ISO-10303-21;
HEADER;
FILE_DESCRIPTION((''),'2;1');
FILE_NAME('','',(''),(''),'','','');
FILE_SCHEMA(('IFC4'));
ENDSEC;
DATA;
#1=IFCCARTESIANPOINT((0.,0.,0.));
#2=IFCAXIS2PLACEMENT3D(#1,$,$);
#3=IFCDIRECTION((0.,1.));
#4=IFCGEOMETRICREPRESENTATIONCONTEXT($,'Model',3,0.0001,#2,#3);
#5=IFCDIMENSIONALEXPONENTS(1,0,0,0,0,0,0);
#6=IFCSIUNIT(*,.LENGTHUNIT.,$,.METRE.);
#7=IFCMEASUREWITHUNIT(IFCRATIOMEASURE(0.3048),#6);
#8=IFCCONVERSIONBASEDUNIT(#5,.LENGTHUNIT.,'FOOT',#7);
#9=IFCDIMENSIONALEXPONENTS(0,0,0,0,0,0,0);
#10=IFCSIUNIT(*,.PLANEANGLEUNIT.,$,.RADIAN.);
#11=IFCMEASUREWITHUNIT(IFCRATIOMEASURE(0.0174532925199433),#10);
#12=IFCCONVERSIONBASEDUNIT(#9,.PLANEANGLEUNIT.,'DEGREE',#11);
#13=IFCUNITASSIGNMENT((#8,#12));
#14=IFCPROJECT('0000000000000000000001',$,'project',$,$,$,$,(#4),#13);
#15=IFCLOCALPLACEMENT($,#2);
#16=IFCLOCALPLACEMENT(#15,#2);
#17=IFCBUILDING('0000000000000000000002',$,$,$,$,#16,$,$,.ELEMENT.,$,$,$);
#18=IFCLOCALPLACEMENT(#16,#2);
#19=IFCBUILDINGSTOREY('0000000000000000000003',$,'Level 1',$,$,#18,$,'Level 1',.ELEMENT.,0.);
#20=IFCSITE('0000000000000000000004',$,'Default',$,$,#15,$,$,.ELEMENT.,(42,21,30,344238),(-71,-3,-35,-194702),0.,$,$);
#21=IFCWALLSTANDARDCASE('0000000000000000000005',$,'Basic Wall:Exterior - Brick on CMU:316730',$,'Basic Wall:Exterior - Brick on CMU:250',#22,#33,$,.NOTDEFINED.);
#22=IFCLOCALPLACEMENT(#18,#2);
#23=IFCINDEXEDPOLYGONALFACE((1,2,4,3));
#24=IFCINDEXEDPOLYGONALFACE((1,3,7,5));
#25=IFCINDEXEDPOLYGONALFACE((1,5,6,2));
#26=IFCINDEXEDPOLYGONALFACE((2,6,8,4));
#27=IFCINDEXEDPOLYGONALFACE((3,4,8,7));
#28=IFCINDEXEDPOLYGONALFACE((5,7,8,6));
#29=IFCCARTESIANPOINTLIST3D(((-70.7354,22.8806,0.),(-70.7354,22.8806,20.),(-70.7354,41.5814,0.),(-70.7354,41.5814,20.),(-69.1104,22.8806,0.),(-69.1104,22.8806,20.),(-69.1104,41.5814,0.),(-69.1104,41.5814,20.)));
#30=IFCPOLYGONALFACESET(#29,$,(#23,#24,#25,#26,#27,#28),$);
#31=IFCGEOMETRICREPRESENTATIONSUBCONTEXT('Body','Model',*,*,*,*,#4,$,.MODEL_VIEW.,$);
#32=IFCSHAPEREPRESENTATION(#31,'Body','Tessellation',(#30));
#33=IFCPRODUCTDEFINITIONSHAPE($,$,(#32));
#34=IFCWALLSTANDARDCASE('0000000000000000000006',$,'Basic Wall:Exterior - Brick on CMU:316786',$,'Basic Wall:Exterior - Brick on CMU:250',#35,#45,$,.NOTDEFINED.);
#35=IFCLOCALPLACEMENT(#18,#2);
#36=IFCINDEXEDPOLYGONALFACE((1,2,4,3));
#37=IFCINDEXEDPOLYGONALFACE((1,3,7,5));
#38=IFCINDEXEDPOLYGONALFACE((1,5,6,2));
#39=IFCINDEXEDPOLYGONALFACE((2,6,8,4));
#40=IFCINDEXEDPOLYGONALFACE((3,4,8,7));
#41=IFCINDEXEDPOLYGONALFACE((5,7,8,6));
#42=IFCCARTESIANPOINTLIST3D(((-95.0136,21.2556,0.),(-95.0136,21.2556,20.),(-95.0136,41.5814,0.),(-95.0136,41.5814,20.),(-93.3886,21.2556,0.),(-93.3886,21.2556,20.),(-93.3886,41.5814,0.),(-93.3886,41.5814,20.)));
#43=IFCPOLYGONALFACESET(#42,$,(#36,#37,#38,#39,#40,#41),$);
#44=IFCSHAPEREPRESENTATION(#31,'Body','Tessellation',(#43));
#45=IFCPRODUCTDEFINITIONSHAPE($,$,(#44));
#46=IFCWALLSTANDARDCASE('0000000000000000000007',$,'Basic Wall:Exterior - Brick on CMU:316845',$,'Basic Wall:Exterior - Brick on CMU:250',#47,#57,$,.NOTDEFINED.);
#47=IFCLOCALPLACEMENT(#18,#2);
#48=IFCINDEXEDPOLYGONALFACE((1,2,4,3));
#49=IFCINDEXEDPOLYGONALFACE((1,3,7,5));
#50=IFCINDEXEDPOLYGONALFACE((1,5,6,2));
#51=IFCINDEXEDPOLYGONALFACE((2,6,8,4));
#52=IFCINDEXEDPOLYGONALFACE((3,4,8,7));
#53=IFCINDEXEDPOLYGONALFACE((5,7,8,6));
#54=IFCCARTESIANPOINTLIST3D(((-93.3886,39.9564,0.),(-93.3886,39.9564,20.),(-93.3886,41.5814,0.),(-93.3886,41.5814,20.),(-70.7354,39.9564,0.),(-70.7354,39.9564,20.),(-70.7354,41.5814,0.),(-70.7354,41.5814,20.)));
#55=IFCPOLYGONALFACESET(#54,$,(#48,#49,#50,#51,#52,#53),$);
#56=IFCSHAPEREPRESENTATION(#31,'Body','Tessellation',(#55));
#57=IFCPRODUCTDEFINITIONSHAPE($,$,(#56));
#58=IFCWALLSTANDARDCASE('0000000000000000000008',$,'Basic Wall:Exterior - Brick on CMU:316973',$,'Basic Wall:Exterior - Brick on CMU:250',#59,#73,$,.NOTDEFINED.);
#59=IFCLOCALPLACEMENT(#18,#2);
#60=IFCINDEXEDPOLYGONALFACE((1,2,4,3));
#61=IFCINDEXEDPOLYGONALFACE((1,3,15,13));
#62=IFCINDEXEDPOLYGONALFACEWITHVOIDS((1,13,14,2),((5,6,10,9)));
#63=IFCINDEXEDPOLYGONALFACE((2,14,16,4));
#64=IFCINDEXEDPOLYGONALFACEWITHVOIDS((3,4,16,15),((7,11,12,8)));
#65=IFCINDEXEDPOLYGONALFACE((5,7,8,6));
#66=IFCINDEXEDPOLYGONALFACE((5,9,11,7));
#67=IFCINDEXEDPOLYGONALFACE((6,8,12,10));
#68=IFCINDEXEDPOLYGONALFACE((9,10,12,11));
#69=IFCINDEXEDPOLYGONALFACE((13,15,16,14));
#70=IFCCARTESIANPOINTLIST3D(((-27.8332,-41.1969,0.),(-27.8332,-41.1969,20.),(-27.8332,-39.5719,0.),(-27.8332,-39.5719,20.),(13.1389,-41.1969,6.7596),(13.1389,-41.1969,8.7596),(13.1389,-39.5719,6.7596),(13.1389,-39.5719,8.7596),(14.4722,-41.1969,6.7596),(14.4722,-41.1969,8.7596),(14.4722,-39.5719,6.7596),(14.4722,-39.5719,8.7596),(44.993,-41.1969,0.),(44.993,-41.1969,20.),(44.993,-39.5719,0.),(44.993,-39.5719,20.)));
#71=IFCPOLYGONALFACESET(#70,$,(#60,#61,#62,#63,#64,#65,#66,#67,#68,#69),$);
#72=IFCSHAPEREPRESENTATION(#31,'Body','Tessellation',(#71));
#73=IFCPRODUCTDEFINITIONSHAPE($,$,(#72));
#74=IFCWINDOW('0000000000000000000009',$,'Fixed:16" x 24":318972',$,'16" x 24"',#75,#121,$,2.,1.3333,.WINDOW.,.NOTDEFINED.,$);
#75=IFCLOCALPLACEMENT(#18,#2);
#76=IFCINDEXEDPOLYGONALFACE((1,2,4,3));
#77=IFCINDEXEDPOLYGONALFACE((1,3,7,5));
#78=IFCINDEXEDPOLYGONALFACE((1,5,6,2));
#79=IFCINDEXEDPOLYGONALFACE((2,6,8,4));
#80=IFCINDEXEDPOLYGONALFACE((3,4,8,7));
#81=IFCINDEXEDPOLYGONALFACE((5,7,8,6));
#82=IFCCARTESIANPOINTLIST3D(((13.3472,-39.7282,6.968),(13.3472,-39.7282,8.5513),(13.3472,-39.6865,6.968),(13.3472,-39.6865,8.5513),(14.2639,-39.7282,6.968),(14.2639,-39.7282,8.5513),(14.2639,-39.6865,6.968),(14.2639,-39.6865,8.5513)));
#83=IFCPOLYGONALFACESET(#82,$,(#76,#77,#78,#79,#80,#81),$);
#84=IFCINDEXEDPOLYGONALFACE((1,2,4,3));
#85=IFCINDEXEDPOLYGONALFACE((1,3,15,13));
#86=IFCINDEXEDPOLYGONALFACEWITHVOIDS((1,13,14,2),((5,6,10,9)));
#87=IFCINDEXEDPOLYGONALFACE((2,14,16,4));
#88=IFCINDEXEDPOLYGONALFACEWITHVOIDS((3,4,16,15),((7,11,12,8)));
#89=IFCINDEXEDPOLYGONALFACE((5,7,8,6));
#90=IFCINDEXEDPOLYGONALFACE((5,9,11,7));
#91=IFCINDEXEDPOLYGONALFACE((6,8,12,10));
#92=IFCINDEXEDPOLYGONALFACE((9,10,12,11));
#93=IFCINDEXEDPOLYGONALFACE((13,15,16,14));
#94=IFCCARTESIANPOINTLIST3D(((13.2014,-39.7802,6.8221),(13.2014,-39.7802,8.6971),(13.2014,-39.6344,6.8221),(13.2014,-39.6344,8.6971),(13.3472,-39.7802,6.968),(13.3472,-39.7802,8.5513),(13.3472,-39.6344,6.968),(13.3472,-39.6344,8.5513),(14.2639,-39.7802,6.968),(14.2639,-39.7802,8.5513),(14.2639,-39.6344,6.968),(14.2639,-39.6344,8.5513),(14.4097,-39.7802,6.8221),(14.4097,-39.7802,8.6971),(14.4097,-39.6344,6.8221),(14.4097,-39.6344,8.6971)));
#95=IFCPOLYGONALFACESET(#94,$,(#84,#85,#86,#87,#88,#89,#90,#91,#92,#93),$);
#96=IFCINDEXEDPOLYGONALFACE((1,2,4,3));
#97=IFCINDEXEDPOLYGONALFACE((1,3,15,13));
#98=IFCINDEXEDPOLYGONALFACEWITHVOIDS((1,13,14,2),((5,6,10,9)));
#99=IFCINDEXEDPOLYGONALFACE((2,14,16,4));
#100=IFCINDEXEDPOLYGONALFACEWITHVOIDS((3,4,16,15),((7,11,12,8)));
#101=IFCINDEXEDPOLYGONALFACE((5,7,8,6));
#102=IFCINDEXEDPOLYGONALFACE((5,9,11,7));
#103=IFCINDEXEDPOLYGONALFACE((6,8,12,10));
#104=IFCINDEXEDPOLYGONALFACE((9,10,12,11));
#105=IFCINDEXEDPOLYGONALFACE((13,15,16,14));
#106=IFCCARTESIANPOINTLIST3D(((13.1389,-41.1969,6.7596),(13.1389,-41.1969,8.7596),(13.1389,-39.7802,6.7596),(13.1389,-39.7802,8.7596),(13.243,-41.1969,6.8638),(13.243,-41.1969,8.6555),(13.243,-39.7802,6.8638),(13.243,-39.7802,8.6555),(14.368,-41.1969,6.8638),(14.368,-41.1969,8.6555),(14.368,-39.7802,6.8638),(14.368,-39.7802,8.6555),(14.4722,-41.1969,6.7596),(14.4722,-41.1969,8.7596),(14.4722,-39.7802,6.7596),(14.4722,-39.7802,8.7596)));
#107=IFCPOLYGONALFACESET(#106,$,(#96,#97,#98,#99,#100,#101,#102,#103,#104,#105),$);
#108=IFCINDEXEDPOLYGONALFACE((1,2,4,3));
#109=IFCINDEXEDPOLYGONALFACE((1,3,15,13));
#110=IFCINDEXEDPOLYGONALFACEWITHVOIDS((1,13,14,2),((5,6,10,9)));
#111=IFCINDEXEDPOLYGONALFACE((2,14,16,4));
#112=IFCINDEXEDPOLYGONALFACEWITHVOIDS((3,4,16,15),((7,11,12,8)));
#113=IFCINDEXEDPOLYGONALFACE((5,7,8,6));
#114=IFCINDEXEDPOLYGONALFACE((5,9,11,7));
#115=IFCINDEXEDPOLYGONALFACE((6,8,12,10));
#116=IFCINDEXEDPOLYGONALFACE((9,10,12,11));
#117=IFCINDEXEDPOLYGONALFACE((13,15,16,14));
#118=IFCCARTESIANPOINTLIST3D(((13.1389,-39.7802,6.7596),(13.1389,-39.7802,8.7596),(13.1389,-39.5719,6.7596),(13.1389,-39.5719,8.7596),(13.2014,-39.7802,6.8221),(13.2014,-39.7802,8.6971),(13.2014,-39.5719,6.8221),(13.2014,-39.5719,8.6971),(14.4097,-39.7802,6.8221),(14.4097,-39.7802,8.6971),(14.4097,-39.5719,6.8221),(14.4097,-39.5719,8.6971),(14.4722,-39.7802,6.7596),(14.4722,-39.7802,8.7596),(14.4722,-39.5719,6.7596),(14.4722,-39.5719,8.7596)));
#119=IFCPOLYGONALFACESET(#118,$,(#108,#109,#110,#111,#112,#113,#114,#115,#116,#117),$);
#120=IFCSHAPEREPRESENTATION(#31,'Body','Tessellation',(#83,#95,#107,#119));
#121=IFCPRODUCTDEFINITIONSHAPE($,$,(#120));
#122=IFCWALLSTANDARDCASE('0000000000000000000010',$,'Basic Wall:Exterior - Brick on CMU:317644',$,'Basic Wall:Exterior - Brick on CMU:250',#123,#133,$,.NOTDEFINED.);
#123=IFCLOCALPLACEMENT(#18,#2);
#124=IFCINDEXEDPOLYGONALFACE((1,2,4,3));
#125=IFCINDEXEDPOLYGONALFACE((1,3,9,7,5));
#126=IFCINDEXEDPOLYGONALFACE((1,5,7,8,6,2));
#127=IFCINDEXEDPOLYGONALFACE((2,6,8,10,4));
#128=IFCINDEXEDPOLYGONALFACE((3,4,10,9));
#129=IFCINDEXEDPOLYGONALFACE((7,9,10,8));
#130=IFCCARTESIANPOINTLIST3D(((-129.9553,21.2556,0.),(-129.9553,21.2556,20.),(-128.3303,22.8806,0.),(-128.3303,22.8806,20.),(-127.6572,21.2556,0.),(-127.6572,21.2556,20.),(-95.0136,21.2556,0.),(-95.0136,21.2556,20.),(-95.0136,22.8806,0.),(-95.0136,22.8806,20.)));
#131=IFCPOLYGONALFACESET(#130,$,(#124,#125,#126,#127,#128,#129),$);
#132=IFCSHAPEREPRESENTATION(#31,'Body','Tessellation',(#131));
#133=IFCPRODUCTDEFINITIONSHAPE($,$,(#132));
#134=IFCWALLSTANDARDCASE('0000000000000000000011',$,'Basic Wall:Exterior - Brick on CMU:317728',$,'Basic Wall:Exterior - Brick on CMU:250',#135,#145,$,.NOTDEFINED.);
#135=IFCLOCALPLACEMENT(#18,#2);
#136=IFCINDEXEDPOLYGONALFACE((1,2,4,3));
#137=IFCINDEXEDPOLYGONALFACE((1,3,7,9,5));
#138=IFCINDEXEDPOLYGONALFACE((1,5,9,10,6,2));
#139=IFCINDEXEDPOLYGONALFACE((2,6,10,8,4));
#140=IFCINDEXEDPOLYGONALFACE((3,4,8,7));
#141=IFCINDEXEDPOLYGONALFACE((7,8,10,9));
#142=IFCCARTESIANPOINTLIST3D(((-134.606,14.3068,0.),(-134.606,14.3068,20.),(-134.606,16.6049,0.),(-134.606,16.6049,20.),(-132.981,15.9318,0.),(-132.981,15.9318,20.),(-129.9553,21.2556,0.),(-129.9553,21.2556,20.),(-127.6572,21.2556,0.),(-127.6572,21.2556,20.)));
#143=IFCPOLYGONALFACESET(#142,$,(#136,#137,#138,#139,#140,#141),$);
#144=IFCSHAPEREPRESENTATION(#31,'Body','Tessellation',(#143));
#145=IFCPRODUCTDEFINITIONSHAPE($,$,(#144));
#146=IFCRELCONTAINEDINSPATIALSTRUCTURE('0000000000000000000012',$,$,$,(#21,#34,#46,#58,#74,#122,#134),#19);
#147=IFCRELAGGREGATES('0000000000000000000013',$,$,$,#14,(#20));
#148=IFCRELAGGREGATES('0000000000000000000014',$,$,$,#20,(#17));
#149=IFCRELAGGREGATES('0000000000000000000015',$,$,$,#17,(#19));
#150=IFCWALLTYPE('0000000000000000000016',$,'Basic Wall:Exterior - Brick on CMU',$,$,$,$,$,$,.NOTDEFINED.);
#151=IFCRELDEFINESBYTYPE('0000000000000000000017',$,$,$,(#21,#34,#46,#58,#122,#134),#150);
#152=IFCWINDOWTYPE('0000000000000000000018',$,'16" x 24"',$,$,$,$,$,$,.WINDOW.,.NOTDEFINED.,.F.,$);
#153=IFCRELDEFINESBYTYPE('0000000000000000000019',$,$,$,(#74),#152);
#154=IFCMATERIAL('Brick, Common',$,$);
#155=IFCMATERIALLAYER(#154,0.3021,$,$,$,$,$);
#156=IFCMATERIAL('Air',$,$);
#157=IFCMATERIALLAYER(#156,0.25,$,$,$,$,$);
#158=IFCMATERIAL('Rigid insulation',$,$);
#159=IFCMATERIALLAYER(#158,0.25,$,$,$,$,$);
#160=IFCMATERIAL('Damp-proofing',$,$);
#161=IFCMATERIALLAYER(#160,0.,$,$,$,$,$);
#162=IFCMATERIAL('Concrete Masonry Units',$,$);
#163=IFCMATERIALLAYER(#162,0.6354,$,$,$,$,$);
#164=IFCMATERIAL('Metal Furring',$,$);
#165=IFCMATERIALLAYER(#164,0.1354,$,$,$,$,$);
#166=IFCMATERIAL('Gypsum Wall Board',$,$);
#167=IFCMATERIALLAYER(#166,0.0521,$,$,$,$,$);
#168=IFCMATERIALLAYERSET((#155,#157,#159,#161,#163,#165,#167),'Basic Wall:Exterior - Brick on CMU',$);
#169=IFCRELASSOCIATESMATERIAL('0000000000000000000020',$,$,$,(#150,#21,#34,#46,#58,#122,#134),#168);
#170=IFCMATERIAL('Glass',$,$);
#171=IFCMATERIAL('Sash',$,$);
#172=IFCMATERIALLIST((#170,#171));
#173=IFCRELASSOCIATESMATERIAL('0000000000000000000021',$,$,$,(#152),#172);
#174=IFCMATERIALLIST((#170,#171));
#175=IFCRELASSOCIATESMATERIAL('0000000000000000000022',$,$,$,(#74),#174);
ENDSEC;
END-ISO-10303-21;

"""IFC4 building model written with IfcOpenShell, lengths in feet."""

from ifc_helpers import new_model, entity, si_unit, converted_unit, direction, frame, frame_2d, origin, place, context, subcontext, project, spatial, polyline, rectangle, outline, extrude, source, transform, mapped, material, material_list, layer, layer_set, layer_usage, type_object, type_shapes, element, fill, save


model = new_model("IFC4")

# Units and contexts
model_context = context("Model", 3, precision=0.0001, world=origin(), true_north=direction((0.0, 1.0)))
body_context = subcontext(model_context, "Body", "Model", "MODEL_VIEW")
ifc_project = project(units=[converted_unit("LENGTHUNIT", "FOOT", entity("IfcRatioMeasure", 0.3048), si_unit("LENGTHUNIT", "METRE"), dimensions=[1, 0, 0, 0, 0, 0, 0]), converted_unit("PLANEANGLEUNIT", "DEGREE", entity("IfcRatioMeasure", 0.0174532925199433), si_unit("PLANEANGLEUNIT", "RADIAN"), dimensions=[0, 0, 0, 0, 0, 0, 0])], contexts=[model_context])

# Site, building, storey
site_placement = place(None, origin())
site = spatial("IfcSite", under=ifc_project, at=site_placement, Name="Default", CompositionType="ELEMENT", RefLatitude=(42, 21, 30, 344238), RefLongitude=(-71, -3, -35, -194702), RefElevation=0.0)
building_placement = place(site_placement, origin())
building = spatial("IfcBuilding", under=site, at=building_placement, CompositionType="ELEMENT")
storey_placement = place(building_placement, origin())
storey = spatial("IfcBuildingStorey", under=building, at=storey_placement, Name="Level 1", LongName="Level 1", CompositionType="ELEMENT", Elevation=0.0)

# Shared definitions
ifc_material_1 = material(Name="Brick, Common")
ifc_layer_1 = layer(ifc_material_1, 0.3021)
ifc_material_2 = material(Name="Air")
ifc_layer_2 = layer(ifc_material_2, 0.25)
ifc_material_3 = material(Name="Rigid insulation")
ifc_layer_3 = layer(ifc_material_3, 0.25)
ifc_material_4 = material(Name="Damp-proofing")
ifc_layer_4 = layer(ifc_material_4, 0.0)
ifc_material_5 = material(Name="Concrete Masonry Units")
ifc_layer_5 = layer(ifc_material_5, 0.6354)
ifc_material_6 = material(Name="Metal Furring")
ifc_layer_6 = layer(ifc_material_6, 0.1354)
ifc_material_7 = material(Name="Gypsum Wall Board")
ifc_layer_7 = layer(ifc_material_7, 0.0521)
ifc_layer_set = layer_set([ifc_layer_1, ifc_layer_2, ifc_layer_3, ifc_layer_4, ifc_layer_5, ifc_layer_6, ifc_layer_7], Name="Basic Wall:Exterior - Brick on CMU")
wall_type = type_object("IfcWallType", Name="Basic Wall:Exterior - Brick on CMU", PredefinedType="NOTDEFINED", material=ifc_layer_set)
ifc_material_8 = material(Name="Glass")
ifc_material_9 = material(Name="Sash")
ifc_material_list_1 = material_list([ifc_material_8, ifc_material_9])
window_type = type_object("IfcWindowType", Name="16\" x 24\"", ParameterTakesPrecedence=False, PartitioningType="NOTDEFINED", PredefinedType="WINDOW", material=ifc_material_list_1)
shared_shape_1 = source(origin(), body_context, "Body", "SweptSolid", [
    extrude(rectangle(XDim=0.0417, YDim=0.9167, at=frame_2d((0.0, 0.0), x_axis=(1.0, 0.0))), frame((0.6667, 1.4896, 0.2083), z_axis=(0.0, 0.0, 1.0), x_axis=(0.0, 1.0, 0.0)), (0.0, 0.0, 1.0), 1.5833),
    extrude(outline(polyline([(-0.6042, -0.9375), (0.6042, -0.9375), (0.6042, 0.9375), (-0.6042, 0.9375), (-0.6042, -0.9375)]), holes=[polyline([(-0.4583, -0.7917), (-0.4583, 0.7917), (0.4583, 0.7917), (0.4583, -0.7917), (-0.4583, -0.7917)])]), frame((0.6667, 1.4167, 1.0), z_axis=(0.0, 1.0, 0.0), x_axis=(1.0, 0.0, 0.0)), (0.0, 0.0, 1.0), 0.1458),
    extrude(outline(polyline([(-0.6667, -1.0), (0.6667, -1.0), (0.6667, 1.0), (-0.6667, 1.0), (-0.6667, -1.0)]), holes=[polyline([(-0.5625, -0.8958), (-0.5625, 0.8958), (0.5625, 0.8958), (0.5625, -0.8958), (-0.5625, -0.8958)])]), frame((0.6667, 0.0, 1.0), z_axis=(0.0, 1.0, 0.0), x_axis=(1.0, 0.0, 0.0)), (0.0, 0.0, 1.0), 1.4167),
    extrude(outline(polyline([(-1.0, -0.6667), (1.0, -0.6667), (1.0, 0.6667), (-1.0, 0.6667), (-1.0, -0.6667)]), holes=[polyline([(-0.9375, -0.6042), (-0.9375, 0.6042), (0.9375, 0.6042), (0.9375, -0.6042), (-0.9375, -0.6042)])]), frame((0.6667, 1.4167, 1.0), z_axis=(0.0, 1.0, 0.0), x_axis=(0.0, 0.0, -1.0)), (0.0, 0.0, 1.0), 0.2083),
])
type_shapes(window_type, [shared_shape_1])

# Walls
ifc_layer_usage_1 = layer_usage(ifc_layer_set, "AXIS2", "NEGATIVE", 0.8125)
wall_1_placement = place(storey_placement, frame((-69.9229, 41.5814, 0.0), z_axis=(0.0, 0.0, 1.0), x_axis=(0.0, -1.0, 0.0)))
element("IfcWallStandardCase", 1, at=wall_1_placement, inside=storey, type_object=wall_type, material=ifc_layer_usage_1, Name="Basic Wall:Exterior - Brick on CMU:316730", ObjectType="Basic Wall:Exterior - Brick on CMU:250", PredefinedType="NOTDEFINED", context=body_context, shape_type="SweptSolid", body=[
    extrude(rectangle(XDim=18.7008, YDim=1.625, at=frame_2d((9.3504, 0.0), x_axis=(-1.0, 0.0))), origin(), (0.0, 0.0, 1.0), 20.0),
])
ifc_layer_usage_2 = layer_usage(ifc_layer_set, "AXIS2", "NEGATIVE", 0.8125)
wall_2_placement = place(storey_placement, frame((-94.2011, 21.2556, 0.0), z_axis=(0.0, 0.0, 1.0), x_axis=(0.0, 1.0, 0.0)))
element("IfcWallStandardCase", 2, at=wall_2_placement, inside=storey, type_object=wall_type, material=ifc_layer_usage_2, Name="Basic Wall:Exterior - Brick on CMU:316786", ObjectType="Basic Wall:Exterior - Brick on CMU:250", PredefinedType="NOTDEFINED", context=body_context, shape_type="SweptSolid", body=[
    extrude(rectangle(XDim=20.3258, YDim=1.625, at=frame_2d((10.1629, 0.0), x_axis=(-1.0, 0.0))), origin(), (0.0, 0.0, 1.0), 20.0),
])
ifc_layer_usage_3 = layer_usage(ifc_layer_set, "AXIS2", "NEGATIVE", 0.8125)
wall_3_placement = place(storey_placement, frame((-70.7354, 40.7689, 0.0), z_axis=(0.0, 0.0, 1.0), x_axis=(-1.0, 0.0, 0.0)))
element("IfcWallStandardCase", 3, at=wall_3_placement, inside=storey, type_object=wall_type, material=ifc_layer_usage_3, Name="Basic Wall:Exterior - Brick on CMU:316845", ObjectType="Basic Wall:Exterior - Brick on CMU:250", PredefinedType="NOTDEFINED", context=body_context, shape_type="SweptSolid", body=[
    extrude(rectangle(XDim=22.6532, YDim=1.625, at=frame_2d((11.3266, 0.0), x_axis=(-1.0, 0.0))), origin(), (0.0, 0.0, 1.0), 20.0),
])

# Wall, opening, window
ifc_layer_usage_4 = layer_usage(ifc_layer_set, "AXIS2", "NEGATIVE", 0.8125)
wall_4_placement = place(storey_placement, frame((44.993, -40.3844, 0.0), z_axis=(0.0, 0.0, 1.0), x_axis=(-1.0, 0.0, 0.0)))
wall_4 = element("IfcWallStandardCase", 4, at=wall_4_placement, inside=storey, type_object=wall_type, material=ifc_layer_usage_4, Name="Basic Wall:Exterior - Brick on CMU:316973", ObjectType="Basic Wall:Exterior - Brick on CMU:250", PredefinedType="NOTDEFINED", context=body_context, shape_type="SweptSolid", body=[
    extrude(rectangle(XDim=72.8262, YDim=1.625, at=frame_2d((36.4131, 0.0), x_axis=(-1.0, 0.0))), origin(), (0.0, 0.0, 1.0), 20.0),
])
opening_1_placement = place(wall_4_placement, frame((31.8542, 0.8125, 6.7596)))
opening_1 = element("IfcOpeningElement", 5, at=opening_1_placement, cuts=wall_4, ObjectType="Opening", PredefinedType="OPENING", context=body_context, shape_type="SweptSolid", body=[
    extrude(rectangle(XDim=2.0, YDim=1.3333, at=frame_2d((1.0, 0.6667), x_axis=(-1.0, 0.0))), frame((0.0, 0.0, 0.0), z_axis=(0.0, -1.0, 0.0), x_axis=(0.0, 0.0, 1.0)), (0.0, 0.0, 1.0), 1.625),
])
ifc_material_list_2 = material_list([ifc_material_8, ifc_material_9])
window_1_placement = place(opening_1_placement, frame((0.0, 0.0, 0.0), z_axis=(0.0, 0.0, 1.0), x_axis=(-1.0, 0.0, 0.0)))
window_1 = element("IfcWindow", 6, at=window_1_placement, inside=storey, type_object=window_type, material=ifc_material_list_2, Name="Fixed:16\" x 24\":318972", ObjectType="16\" x 24\"", OverallHeight=2.0, OverallWidth=1.3333, PartitioningType="NOTDEFINED", PredefinedType="WINDOW", context=body_context, shape_type="MappedRepresentation", body=[
    mapped(shared_shape_1, transform((0.0, 0.0, 0.0), scale=1.0)),
])
fill(opening_1, window_1)

# Walls
ifc_layer_usage_5 = layer_usage(ifc_layer_set, "AXIS2", "NEGATIVE", 0.8125)
wall_5_placement = place(storey_placement, frame((-95.0136, 22.0681, 0.0), z_axis=(0.0, 0.0, 1.0), x_axis=(-1.0, 0.0, 0.0)))
element("IfcWallStandardCase", 7, at=wall_5_placement, inside=storey, type_object=wall_type, material=ifc_layer_usage_5, Name="Basic Wall:Exterior - Brick on CMU:317644", ObjectType="Basic Wall:Exterior - Brick on CMU:250", PredefinedType="NOTDEFINED", context=body_context, shape_type="SweptSolid", body=[
    extrude(outline(polyline([(33.3167, -0.8125), (34.9417, 0.8125), (32.6436, 0.8125), (0.0, 0.8125), (0.0, -0.8125), (33.3167, -0.8125)])), origin(), (0.0, 0.0, 1.0), 20.0),
])
ifc_layer_usage_6 = layer_usage(ifc_layer_set, "AXIS2", "NEGATIVE", 0.8125)
wall_6_placement = place(storey_placement, frame((-128.2317, 21.8302, 0.0), z_axis=(0.0, 0.0, 1.0), x_axis=(-0.707107, -0.707107, 0.0)))
element("IfcWallStandardCase", 8, at=wall_6_placement, inside=storey, type_object=wall_type, material=ifc_layer_usage_6, Name="Basic Wall:Exterior - Brick on CMU:317728", ObjectType="Basic Wall:Exterior - Brick on CMU:250", PredefinedType="NOTDEFINED", context=body_context, shape_type="SweptSolid", body=[
    extrude(outline(polyline([(8.2021, -0.8125), (9.8271, 0.8125), (7.529, 0.8125), (0.0, 0.8125), (1.625, -0.8125), (8.2021, -0.8125)])), origin(), (0.0, 0.0, 1.0), 20.0),
])

save(model, "model.ifc")
